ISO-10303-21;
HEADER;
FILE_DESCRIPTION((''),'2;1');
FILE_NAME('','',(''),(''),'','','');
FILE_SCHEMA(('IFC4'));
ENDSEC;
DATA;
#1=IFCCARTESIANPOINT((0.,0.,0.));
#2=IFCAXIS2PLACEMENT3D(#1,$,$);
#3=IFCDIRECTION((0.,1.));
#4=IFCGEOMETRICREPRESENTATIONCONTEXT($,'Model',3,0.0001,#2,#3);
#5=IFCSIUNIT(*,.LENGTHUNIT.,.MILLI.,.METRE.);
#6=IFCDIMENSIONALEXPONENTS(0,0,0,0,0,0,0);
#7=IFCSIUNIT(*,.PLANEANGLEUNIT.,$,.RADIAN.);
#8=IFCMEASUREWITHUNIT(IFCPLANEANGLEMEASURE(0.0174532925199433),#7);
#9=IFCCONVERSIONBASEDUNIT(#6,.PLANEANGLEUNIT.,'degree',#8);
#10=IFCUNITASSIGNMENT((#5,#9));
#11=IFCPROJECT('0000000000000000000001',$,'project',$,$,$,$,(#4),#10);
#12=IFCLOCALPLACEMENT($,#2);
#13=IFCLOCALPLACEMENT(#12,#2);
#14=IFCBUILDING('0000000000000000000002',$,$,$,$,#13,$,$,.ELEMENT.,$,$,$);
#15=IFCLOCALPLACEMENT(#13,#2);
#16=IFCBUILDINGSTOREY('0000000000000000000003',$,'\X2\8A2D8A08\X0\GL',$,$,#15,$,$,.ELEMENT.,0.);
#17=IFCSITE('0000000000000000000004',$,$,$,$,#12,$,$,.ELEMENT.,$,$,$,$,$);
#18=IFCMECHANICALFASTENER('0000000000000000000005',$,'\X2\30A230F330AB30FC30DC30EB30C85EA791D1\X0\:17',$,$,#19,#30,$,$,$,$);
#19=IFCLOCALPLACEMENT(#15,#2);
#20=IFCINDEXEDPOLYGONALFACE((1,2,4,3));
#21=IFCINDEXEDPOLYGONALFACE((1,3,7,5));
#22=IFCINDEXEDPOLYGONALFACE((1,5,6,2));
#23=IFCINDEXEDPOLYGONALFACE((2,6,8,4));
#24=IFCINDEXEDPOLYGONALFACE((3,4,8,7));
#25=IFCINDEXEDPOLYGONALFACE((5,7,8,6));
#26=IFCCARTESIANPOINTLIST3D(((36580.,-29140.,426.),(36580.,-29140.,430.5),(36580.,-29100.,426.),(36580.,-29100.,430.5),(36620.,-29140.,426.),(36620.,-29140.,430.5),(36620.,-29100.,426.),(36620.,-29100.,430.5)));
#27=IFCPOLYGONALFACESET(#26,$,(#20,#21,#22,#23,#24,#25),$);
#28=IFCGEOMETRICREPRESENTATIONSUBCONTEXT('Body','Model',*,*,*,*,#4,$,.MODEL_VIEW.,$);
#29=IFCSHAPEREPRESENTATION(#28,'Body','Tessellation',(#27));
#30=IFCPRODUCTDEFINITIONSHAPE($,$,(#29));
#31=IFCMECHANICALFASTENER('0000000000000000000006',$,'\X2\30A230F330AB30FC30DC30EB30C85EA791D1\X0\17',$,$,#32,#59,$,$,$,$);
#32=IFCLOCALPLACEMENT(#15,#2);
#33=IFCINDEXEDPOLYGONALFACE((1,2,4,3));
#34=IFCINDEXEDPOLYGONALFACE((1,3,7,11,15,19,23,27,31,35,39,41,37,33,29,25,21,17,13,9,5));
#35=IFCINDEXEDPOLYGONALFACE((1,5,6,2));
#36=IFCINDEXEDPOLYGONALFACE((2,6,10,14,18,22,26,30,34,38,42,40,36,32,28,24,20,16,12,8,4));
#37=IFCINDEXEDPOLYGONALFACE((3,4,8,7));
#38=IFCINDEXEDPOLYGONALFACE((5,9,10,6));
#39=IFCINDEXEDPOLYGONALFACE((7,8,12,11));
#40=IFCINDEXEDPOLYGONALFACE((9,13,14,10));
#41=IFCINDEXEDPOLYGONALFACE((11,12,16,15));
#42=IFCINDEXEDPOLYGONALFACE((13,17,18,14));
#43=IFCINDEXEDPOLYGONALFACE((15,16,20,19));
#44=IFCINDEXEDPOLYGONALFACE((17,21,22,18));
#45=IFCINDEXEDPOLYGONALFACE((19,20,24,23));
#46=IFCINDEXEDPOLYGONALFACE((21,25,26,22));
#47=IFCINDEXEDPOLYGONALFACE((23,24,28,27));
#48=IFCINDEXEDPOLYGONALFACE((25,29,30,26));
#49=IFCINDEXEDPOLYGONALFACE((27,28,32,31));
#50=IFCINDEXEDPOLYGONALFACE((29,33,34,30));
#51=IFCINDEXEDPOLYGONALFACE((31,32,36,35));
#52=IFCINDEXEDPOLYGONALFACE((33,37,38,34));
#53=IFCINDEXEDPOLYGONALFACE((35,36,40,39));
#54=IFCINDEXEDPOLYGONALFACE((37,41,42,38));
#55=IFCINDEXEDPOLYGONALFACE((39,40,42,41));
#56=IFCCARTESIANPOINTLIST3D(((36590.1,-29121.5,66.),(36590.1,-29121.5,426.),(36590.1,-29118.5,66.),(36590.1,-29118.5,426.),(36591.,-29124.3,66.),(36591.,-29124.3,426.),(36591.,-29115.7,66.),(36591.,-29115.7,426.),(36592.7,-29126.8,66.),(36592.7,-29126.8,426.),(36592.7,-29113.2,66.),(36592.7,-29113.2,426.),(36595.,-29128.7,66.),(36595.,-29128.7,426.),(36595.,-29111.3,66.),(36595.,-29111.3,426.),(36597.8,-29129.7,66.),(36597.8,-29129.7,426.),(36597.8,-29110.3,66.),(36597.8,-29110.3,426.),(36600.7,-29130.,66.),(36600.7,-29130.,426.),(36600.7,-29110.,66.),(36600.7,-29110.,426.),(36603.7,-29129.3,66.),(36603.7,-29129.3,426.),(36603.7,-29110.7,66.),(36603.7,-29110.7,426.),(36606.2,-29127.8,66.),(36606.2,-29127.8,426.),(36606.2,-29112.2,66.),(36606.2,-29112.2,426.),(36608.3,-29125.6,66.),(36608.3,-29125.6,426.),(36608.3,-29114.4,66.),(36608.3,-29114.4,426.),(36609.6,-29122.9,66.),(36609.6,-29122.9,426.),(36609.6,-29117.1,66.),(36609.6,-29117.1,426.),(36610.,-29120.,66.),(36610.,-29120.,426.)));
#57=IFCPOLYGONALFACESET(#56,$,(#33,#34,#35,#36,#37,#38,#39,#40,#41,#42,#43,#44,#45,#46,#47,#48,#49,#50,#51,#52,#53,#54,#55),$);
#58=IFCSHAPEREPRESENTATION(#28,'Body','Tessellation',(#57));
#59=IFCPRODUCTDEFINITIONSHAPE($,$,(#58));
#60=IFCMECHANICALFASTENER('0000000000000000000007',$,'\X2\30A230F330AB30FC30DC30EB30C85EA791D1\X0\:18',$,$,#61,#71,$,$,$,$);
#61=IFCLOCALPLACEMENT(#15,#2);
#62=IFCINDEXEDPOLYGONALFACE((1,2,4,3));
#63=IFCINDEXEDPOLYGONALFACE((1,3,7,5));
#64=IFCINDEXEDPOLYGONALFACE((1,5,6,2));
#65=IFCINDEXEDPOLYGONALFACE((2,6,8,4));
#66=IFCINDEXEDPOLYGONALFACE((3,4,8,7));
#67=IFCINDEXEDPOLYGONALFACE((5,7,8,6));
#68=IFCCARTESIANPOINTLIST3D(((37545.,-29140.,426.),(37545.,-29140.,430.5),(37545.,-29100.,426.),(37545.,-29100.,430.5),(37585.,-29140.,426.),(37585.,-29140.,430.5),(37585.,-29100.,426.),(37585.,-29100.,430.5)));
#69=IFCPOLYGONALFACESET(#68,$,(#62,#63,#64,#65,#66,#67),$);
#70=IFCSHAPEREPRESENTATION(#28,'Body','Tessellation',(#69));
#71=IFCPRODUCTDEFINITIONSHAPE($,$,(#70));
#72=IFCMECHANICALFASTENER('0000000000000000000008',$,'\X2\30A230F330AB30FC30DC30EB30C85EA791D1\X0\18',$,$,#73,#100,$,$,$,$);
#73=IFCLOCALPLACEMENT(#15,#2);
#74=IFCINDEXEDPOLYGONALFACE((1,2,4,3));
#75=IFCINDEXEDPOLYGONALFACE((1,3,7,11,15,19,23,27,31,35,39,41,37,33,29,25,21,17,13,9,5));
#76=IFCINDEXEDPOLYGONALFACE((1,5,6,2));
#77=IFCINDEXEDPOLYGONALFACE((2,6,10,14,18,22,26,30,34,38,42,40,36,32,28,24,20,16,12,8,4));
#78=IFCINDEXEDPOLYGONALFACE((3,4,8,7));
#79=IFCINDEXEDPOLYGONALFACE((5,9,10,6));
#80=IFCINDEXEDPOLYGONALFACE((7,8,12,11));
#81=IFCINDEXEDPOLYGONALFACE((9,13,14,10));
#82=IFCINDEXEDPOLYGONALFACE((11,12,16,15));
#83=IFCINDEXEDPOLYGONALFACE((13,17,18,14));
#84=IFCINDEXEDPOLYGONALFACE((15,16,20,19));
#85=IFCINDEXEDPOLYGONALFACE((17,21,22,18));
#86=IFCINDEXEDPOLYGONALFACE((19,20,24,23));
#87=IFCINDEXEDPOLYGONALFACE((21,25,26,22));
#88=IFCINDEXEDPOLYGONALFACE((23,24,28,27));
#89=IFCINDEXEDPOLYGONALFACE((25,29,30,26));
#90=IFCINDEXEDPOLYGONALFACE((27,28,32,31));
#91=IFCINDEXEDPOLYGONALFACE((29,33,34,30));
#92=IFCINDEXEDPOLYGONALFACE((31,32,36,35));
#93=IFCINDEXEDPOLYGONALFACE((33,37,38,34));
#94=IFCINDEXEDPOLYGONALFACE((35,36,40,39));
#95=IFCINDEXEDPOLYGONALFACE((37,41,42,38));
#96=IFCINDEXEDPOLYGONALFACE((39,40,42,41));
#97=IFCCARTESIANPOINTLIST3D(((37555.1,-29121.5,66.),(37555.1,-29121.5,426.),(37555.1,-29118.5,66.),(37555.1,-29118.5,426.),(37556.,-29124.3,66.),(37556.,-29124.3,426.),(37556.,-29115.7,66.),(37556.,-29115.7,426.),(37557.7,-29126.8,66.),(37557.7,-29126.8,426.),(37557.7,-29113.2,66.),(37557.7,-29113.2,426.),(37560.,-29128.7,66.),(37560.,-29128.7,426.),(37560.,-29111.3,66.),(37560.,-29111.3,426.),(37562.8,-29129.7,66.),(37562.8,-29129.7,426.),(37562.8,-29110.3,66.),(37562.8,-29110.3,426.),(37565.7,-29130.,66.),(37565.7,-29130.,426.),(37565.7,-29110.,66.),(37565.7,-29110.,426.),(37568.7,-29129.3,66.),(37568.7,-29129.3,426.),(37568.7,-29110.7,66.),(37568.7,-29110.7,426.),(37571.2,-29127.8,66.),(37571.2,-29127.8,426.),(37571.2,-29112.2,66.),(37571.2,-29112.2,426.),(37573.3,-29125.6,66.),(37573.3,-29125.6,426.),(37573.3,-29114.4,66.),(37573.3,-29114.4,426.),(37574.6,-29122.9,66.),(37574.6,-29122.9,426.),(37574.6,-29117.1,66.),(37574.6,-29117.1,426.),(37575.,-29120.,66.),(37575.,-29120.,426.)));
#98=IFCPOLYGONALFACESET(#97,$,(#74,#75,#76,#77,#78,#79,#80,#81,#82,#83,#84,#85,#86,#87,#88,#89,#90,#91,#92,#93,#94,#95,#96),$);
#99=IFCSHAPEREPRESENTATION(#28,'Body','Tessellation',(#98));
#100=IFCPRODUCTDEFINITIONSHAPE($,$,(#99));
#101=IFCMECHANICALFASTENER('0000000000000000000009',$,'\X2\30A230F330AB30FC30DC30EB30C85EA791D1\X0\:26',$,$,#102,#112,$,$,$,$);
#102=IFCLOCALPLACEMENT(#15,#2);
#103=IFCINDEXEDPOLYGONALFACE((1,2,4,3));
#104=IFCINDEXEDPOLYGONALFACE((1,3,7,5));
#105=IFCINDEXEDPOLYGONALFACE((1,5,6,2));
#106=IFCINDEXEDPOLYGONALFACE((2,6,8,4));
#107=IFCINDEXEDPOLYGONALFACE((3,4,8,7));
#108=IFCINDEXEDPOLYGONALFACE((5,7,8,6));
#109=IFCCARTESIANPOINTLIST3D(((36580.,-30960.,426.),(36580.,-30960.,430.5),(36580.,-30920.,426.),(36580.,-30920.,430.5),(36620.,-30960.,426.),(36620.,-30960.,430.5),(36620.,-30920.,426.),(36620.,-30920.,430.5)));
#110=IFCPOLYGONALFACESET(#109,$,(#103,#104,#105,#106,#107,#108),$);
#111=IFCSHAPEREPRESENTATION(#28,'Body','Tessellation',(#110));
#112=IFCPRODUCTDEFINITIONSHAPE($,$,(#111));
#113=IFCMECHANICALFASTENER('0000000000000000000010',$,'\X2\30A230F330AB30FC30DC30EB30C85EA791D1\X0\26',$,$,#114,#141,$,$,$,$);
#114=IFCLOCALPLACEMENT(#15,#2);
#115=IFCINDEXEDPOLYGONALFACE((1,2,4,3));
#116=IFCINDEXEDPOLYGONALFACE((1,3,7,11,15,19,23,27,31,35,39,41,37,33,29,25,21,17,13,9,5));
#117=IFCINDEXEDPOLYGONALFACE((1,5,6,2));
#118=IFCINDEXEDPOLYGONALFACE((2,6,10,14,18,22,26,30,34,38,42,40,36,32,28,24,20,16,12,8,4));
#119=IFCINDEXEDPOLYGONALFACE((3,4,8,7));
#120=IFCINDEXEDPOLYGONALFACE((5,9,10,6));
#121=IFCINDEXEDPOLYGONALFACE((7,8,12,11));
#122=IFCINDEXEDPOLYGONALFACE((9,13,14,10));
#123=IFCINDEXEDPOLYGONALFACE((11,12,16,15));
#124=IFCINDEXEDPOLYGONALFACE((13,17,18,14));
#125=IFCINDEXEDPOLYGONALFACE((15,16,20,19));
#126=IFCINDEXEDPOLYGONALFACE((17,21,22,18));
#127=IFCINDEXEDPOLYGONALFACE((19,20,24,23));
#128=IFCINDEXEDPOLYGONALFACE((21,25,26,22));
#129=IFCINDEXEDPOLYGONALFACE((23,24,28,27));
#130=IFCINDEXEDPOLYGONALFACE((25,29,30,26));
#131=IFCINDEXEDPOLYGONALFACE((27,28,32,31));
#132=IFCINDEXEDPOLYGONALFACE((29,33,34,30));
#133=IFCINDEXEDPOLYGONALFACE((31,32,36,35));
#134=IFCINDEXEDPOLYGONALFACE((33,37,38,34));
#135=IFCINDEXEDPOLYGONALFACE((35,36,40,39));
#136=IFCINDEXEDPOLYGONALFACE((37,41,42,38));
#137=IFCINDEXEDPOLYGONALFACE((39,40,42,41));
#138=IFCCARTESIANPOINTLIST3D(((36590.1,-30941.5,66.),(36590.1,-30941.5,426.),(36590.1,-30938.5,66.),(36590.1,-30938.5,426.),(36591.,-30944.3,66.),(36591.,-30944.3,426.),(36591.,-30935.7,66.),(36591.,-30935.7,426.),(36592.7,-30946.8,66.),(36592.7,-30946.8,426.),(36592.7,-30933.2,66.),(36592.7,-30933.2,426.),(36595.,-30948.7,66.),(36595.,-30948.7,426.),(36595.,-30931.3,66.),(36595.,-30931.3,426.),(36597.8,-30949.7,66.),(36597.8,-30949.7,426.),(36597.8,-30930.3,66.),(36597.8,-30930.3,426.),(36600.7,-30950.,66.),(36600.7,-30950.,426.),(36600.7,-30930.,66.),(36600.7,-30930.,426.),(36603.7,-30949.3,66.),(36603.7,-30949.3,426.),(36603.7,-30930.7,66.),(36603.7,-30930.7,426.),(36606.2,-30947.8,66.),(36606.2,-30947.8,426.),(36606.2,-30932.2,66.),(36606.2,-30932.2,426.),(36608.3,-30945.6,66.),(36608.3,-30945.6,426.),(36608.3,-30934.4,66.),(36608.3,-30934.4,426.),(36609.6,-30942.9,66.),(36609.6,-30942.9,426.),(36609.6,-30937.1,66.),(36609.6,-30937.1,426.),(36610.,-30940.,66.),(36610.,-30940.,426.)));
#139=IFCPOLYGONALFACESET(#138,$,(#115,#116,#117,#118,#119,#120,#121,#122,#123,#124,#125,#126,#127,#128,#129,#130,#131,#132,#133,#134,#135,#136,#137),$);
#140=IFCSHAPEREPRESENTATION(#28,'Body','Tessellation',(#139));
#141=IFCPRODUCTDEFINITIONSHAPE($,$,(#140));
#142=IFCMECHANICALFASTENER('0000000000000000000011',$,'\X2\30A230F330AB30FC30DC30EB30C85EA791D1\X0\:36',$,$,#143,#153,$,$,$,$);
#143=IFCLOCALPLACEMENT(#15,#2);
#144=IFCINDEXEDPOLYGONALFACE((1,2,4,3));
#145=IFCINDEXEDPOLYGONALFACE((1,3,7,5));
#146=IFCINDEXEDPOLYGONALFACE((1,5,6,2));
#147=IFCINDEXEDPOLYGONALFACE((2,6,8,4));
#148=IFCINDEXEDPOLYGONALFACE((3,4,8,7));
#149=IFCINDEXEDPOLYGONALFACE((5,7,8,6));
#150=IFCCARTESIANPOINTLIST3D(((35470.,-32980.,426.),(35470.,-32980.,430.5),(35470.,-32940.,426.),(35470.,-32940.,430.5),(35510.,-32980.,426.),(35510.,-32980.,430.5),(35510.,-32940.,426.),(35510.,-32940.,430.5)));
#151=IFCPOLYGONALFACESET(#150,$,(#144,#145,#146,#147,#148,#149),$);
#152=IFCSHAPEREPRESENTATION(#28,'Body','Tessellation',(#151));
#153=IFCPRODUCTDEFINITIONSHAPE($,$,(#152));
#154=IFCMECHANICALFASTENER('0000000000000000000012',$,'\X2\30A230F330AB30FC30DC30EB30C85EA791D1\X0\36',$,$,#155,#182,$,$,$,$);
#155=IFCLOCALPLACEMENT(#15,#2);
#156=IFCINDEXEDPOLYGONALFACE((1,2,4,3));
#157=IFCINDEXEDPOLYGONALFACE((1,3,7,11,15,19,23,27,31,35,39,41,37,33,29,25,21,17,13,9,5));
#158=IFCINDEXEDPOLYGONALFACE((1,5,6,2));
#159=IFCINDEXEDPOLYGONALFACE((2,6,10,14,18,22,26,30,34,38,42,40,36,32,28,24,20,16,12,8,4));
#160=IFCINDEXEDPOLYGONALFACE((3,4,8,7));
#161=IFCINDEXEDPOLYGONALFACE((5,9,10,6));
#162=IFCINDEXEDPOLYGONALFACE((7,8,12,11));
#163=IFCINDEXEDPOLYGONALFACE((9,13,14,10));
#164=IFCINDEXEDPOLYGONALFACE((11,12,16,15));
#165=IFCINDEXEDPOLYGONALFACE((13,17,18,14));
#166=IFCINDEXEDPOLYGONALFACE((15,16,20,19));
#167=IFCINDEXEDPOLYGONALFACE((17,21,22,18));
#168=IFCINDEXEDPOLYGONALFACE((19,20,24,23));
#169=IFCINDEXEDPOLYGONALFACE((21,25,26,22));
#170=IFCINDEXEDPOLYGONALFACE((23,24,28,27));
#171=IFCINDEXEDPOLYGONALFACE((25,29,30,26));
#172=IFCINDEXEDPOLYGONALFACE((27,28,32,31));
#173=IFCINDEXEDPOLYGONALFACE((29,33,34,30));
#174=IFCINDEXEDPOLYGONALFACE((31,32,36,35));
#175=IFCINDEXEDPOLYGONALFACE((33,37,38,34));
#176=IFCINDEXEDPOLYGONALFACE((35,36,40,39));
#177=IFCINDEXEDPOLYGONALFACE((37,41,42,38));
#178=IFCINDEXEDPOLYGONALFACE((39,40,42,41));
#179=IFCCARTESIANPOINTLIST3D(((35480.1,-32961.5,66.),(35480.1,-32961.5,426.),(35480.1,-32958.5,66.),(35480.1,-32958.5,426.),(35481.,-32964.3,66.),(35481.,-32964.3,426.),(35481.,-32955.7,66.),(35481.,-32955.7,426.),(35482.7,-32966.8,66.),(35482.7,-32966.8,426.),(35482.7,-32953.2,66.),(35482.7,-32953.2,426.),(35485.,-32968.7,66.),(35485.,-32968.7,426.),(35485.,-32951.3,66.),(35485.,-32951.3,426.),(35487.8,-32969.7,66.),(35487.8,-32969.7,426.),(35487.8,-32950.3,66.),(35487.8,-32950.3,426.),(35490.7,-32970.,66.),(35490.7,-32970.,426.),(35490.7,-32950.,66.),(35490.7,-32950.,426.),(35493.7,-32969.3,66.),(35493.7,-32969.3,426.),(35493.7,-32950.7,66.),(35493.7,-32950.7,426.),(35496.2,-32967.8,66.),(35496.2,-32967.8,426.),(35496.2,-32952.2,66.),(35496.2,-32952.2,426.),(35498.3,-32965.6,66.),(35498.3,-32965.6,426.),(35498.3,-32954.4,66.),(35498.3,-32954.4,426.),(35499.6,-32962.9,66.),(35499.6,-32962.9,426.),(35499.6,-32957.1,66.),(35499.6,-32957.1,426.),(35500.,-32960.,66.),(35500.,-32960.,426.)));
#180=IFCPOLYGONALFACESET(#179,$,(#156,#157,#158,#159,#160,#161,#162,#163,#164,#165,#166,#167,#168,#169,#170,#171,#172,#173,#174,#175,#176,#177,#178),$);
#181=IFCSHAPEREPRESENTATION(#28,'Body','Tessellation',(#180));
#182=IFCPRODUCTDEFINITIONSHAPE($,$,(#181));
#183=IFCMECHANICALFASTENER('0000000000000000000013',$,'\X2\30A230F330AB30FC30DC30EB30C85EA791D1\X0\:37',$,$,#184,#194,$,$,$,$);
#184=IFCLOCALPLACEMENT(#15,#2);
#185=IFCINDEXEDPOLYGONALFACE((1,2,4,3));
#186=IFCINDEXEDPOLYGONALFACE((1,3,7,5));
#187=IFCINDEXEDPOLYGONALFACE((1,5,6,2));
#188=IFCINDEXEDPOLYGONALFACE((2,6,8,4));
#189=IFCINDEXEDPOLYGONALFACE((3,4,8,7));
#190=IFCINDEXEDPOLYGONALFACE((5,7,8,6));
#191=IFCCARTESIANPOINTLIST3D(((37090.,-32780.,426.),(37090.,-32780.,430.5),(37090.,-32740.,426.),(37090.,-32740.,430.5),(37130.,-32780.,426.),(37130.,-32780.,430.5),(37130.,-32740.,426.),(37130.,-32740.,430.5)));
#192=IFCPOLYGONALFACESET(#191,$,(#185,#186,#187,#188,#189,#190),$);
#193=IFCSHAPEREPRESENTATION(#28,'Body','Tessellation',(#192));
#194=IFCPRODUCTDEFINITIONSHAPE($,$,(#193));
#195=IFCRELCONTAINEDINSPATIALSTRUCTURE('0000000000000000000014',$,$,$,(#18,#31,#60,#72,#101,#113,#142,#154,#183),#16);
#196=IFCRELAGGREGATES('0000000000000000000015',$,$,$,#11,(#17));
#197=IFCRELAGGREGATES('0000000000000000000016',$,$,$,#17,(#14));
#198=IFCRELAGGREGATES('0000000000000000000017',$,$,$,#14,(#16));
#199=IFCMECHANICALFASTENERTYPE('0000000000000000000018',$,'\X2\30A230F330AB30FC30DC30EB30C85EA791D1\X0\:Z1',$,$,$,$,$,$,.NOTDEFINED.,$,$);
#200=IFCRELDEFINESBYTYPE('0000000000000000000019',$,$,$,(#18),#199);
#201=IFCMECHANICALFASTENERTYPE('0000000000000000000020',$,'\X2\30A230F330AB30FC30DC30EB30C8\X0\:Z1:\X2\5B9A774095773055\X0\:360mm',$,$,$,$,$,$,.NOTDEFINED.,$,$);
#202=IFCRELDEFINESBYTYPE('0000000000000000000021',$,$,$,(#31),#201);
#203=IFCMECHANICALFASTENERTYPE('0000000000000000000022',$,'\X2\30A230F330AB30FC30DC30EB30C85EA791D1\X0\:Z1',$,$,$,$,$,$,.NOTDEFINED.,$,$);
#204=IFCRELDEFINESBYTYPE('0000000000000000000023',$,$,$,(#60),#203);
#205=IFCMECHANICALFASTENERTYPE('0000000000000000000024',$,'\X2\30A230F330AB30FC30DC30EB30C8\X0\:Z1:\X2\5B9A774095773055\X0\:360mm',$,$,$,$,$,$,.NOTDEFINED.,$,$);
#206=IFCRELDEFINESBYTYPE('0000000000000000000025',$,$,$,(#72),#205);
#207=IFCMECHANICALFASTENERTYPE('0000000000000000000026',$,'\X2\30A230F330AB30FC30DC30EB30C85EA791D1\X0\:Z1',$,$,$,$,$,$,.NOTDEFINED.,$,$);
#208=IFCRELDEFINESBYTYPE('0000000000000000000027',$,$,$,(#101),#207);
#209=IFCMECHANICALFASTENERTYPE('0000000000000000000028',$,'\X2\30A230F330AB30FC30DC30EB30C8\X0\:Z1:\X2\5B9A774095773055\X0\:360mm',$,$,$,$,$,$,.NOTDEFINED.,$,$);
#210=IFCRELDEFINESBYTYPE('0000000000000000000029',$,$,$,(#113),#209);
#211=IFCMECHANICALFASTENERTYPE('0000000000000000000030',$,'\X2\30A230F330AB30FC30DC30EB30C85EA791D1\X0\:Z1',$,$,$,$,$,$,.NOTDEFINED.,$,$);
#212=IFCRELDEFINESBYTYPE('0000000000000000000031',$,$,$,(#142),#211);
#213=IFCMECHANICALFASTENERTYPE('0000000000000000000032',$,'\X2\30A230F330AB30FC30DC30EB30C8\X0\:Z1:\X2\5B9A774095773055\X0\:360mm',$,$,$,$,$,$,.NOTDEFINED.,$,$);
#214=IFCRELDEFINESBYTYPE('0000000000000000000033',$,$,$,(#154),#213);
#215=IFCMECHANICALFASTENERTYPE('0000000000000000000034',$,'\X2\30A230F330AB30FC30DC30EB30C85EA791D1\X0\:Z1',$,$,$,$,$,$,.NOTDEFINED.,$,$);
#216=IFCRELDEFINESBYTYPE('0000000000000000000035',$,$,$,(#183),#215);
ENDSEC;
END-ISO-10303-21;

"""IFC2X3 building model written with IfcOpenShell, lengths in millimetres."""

from ifc_helpers import new_model, entity, si_unit, converted_unit, direction, frame, origin, origin_with_axes, origin_2d, place, context, subcontext, project, spatial, rectangle, circle, extrude, type_object, element, save


model = new_model("IFC2X3")

# Units and contexts
model_context = context("Model", 3, precision=0.0001, world=origin(), true_north=direction((0.0, 1.0)))
body_context = subcontext(model_context, "Body", "Model", "MODEL_VIEW")
ifc_project = project(units=[si_unit("LENGTHUNIT", "METRE", prefix="MILLI"), converted_unit("PLANEANGLEUNIT", "degree", entity("IfcPlaneAngleMeasure", 0.0174532925199433), si_unit("PLANEANGLEUNIT", "RADIAN"), dimensions=[0, 0, 0, 0, 0, 0, 0])], contexts=[model_context])

# Site, building, storey
site_placement = place(None, origin())
site = spatial("IfcSite", under=ifc_project, at=site_placement, CompositionType="ELEMENT")
building_placement = place(site_placement, origin())
building = spatial("IfcBuilding", under=site, at=building_placement, CompositionType="ELEMENT")
storey_placement = place(building_placement, origin())
storey = spatial("IfcBuildingStorey", under=building, at=storey_placement, Name="設計GL", CompositionType="ELEMENT", Elevation=0.0)

# Mechanical fasteners
mechanical_fastener_type_1 = type_object("IfcMechanicalFastenerType", Name="アンカーボルト座金:Z1")
mechanical_fastener_1_placement = place(storey_placement, frame((36600.0, -29120.0, 426.0)))
element("IfcMechanicalFastener", 1, at=mechanical_fastener_1_placement, inside=storey, type_object=mechanical_fastener_type_1, Name="アンカーボルト座金:17", context=body_context, shape_type="SweptSolid", body=[
    extrude(rectangle(XDim=40.0, YDim=40.0, at=origin_2d()), origin_with_axes(), (0.0, 0.0, 1.0), 4.5),
])
mechanical_fastener_type_2 = type_object("IfcMechanicalFastenerType", Name="アンカーボルト:Z1:定着長さ:360mm")
mechanical_fastener_2_placement = place(storey_placement, frame((36600.0, -29120.0, 66.0)))
element("IfcMechanicalFastener", 2, at=mechanical_fastener_2_placement, inside=storey, type_object=mechanical_fastener_type_2, Name="アンカーボルト座金17", context=body_context, shape_type="SweptSolid", body=[
    extrude(circle(Radius=10.0, at=origin_2d()), origin_with_axes(), (0.0, 0.0, 1.0), 360.0),
])
mechanical_fastener_type_3 = type_object("IfcMechanicalFastenerType", Name="アンカーボルト座金:Z1")
mechanical_fastener_3_placement = place(storey_placement, frame((37565.0, -29120.0, 426.0)))
element("IfcMechanicalFastener", 3, at=mechanical_fastener_3_placement, inside=storey, type_object=mechanical_fastener_type_3, Name="アンカーボルト座金:18", context=body_context, shape_type="SweptSolid", body=[
    extrude(rectangle(XDim=40.0, YDim=40.0, at=origin_2d()), origin_with_axes(), (0.0, 0.0, 1.0), 4.5),
])
mechanical_fastener_type_4 = type_object("IfcMechanicalFastenerType", Name="アンカーボルト:Z1:定着長さ:360mm")
mechanical_fastener_4_placement = place(storey_placement, frame((37565.0, -29120.0, 66.0)))
element("IfcMechanicalFastener", 4, at=mechanical_fastener_4_placement, inside=storey, type_object=mechanical_fastener_type_4, Name="アンカーボルト座金18", context=body_context, shape_type="SweptSolid", body=[
    extrude(circle(Radius=10.0, at=origin_2d()), origin_with_axes(), (0.0, 0.0, 1.0), 360.0),
])
mechanical_fastener_type_5 = type_object("IfcMechanicalFastenerType", Name="アンカーボルト座金:Z1")
mechanical_fastener_5_placement = place(storey_placement, frame((36600.0, -30940.0, 426.0)))
element("IfcMechanicalFastener", 5, at=mechanical_fastener_5_placement, inside=storey, type_object=mechanical_fastener_type_5, Name="アンカーボルト座金:26", context=body_context, shape_type="SweptSolid", body=[
    extrude(rectangle(XDim=40.0, YDim=40.0, at=origin_2d()), origin_with_axes(), (0.0, 0.0, 1.0), 4.5),
])
mechanical_fastener_type_6 = type_object("IfcMechanicalFastenerType", Name="アンカーボルト:Z1:定着長さ:360mm")
mechanical_fastener_6_placement = place(storey_placement, frame((36600.0, -30940.0, 66.0)))
element("IfcMechanicalFastener", 6, at=mechanical_fastener_6_placement, inside=storey, type_object=mechanical_fastener_type_6, Name="アンカーボルト座金26", context=body_context, shape_type="SweptSolid", body=[
    extrude(circle(Radius=10.0, at=origin_2d()), origin_with_axes(), (0.0, 0.0, 1.0), 360.0),
])
mechanical_fastener_type_7 = type_object("IfcMechanicalFastenerType", Name="アンカーボルト座金:Z1")
mechanical_fastener_7_placement = place(storey_placement, frame((35490.0, -32960.0, 426.0)))
element("IfcMechanicalFastener", 7, at=mechanical_fastener_7_placement, inside=storey, type_object=mechanical_fastener_type_7, Name="アンカーボルト座金:36", context=body_context, shape_type="SweptSolid", body=[
    extrude(rectangle(XDim=40.0, YDim=40.0, at=origin_2d()), origin_with_axes(), (0.0, 0.0, 1.0), 4.5),
])
mechanical_fastener_type_8 = type_object("IfcMechanicalFastenerType", Name="アンカーボルト:Z1:定着長さ:360mm")
mechanical_fastener_8_placement = place(storey_placement, frame((35490.0, -32960.0, 66.0)))
element("IfcMechanicalFastener", 8, at=mechanical_fastener_8_placement, inside=storey, type_object=mechanical_fastener_type_8, Name="アンカーボルト座金36", context=body_context, shape_type="SweptSolid", body=[
    extrude(circle(Radius=10.0, at=origin_2d()), origin_with_axes(), (0.0, 0.0, 1.0), 360.0),
])
mechanical_fastener_type_9 = type_object("IfcMechanicalFastenerType", Name="アンカーボルト座金:Z1")
mechanical_fastener_9_placement = place(storey_placement, frame((37110.0, -32760.0, 426.0)))
element("IfcMechanicalFastener", 9, at=mechanical_fastener_9_placement, inside=storey, type_object=mechanical_fastener_type_9, Name="アンカーボルト座金:37", context=body_context, shape_type="SweptSolid", body=[
    extrude(rectangle(XDim=40.0, YDim=40.0, at=origin_2d()), origin_with_axes(), (0.0, 0.0, 1.0), 4.5),
])

save(model, "model.ifc")
